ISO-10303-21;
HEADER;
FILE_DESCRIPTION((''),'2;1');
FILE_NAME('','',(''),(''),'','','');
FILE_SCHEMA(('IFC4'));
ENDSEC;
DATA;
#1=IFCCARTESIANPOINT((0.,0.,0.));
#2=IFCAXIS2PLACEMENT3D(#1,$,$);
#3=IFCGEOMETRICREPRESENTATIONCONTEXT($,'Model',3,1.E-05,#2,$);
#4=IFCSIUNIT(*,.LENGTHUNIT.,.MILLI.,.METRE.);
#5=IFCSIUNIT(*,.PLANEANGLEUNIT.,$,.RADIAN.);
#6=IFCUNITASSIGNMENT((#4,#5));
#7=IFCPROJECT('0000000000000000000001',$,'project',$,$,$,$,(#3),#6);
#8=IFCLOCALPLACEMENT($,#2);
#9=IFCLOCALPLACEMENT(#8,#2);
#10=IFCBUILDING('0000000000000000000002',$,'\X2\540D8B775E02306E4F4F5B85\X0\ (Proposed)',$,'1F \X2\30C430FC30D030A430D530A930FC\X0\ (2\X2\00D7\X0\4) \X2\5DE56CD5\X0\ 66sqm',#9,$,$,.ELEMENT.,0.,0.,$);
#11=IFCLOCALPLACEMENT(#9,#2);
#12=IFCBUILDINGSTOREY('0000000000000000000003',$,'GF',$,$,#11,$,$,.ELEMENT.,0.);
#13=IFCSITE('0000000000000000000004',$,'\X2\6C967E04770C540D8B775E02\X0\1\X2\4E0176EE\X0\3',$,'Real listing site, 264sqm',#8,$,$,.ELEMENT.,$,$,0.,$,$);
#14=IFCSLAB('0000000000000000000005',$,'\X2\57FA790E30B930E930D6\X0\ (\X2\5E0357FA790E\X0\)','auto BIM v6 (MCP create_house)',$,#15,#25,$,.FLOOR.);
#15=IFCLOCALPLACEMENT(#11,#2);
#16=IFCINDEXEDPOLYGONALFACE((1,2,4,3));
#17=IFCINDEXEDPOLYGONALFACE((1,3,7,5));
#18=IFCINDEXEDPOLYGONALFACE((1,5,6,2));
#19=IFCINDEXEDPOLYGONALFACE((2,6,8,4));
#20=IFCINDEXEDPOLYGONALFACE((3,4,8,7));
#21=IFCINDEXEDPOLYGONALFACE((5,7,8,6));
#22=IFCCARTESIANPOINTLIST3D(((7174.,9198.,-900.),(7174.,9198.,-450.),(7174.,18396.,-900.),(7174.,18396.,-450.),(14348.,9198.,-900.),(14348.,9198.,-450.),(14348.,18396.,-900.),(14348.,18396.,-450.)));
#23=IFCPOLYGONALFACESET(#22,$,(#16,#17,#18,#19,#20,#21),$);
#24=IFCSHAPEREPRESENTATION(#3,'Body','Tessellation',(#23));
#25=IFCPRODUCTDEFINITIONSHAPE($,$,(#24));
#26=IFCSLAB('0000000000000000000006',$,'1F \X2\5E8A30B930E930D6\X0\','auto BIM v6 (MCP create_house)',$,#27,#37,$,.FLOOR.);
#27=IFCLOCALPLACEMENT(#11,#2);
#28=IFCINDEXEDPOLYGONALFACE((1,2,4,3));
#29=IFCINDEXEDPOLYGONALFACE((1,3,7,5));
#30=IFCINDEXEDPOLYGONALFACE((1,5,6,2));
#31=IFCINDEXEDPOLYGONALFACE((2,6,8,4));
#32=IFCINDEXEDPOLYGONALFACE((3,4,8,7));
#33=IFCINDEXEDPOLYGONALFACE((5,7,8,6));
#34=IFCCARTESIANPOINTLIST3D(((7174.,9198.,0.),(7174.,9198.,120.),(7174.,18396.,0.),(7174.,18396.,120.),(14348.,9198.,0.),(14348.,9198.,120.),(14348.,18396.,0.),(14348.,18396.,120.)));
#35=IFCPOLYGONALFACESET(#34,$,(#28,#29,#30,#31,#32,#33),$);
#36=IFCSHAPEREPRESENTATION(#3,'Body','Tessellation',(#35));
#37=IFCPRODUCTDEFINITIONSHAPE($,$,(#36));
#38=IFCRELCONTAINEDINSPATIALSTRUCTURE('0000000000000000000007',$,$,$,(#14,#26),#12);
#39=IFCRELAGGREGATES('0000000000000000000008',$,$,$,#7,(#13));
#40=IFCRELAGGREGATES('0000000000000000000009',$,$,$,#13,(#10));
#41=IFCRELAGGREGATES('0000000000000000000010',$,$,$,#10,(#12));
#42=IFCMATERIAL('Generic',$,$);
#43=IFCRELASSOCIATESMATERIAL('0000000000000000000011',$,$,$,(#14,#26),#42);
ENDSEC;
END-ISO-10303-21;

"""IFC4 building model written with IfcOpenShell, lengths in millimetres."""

from ifc_helpers import new_model, si_unit, frame, frame_2d, origin, place, context, project, spatial, rectangle, extrude, material, element, save


model = new_model("IFC4")

# Units and contexts
model_context = context("Model", 3, precision=1e-05, world=origin())
ifc_project = project(units=[si_unit("LENGTHUNIT", "METRE", prefix="MILLI"), si_unit("PLANEANGLEUNIT", "RADIAN")], contexts=[model_context])

# Site, building, storey
site_placement = place(None, origin())
site = spatial("IfcSite", under=ifc_project, at=site_placement, Name="沖縄県名護市1丁目3", ObjectType="Real listing site, 264sqm", CompositionType="ELEMENT", RefElevation=0.0)
building_placement = place(site_placement, origin())
building = spatial("IfcBuilding", under=site, at=building_placement, Name="名護市の住宅 (Proposed)", ObjectType="1F ツーバイフォー (2×4) 工法 66sqm", CompositionType="ELEMENT", ElevationOfRefHeight=0.0, ElevationOfTerrain=0.0)
storey_placement = place(building_placement, origin())
storey = spatial("IfcBuildingStorey", under=building, at=storey_placement, Name="GF", CompositionType="ELEMENT", Elevation=0.0)

# Slabs
ifc_material = material(Name="Generic")
slab_1_placement = place(storey_placement, frame((3587.0, 4599.0, -450.0)))
element("IfcSlab", 1, at=slab_1_placement, inside=storey, material=ifc_material, Name="基礎スラブ (布基礎)", Description="auto BIM v6 (MCP create_house)", PredefinedType="FLOOR", context=model_context, shape_type="SweptSolid", body=[
    extrude(rectangle(XDim=7174.0, YDim=9198.0, at=frame_2d((3587.0, 4599.0))), frame((3587.0, 4599.0, -450.0)), (0.0, 0.0, 1.0), 450.0),
])
slab_2_placement = place(storey_placement, frame((3587.0, 4599.0, 0.0)))
element("IfcSlab", 2, at=slab_2_placement, inside=storey, material=ifc_material, Name="1F 床スラブ", Description="auto BIM v6 (MCP create_house)", PredefinedType="FLOOR", context=model_context, shape_type="SweptSolid", body=[
    extrude(rectangle(XDim=7174.0, YDim=9198.0, at=frame_2d((3587.0, 4599.0))), frame((3587.0, 4599.0, 0.0)), (0.0, 0.0, 1.0), 120.0),
])

save(model, "model.ifc")
